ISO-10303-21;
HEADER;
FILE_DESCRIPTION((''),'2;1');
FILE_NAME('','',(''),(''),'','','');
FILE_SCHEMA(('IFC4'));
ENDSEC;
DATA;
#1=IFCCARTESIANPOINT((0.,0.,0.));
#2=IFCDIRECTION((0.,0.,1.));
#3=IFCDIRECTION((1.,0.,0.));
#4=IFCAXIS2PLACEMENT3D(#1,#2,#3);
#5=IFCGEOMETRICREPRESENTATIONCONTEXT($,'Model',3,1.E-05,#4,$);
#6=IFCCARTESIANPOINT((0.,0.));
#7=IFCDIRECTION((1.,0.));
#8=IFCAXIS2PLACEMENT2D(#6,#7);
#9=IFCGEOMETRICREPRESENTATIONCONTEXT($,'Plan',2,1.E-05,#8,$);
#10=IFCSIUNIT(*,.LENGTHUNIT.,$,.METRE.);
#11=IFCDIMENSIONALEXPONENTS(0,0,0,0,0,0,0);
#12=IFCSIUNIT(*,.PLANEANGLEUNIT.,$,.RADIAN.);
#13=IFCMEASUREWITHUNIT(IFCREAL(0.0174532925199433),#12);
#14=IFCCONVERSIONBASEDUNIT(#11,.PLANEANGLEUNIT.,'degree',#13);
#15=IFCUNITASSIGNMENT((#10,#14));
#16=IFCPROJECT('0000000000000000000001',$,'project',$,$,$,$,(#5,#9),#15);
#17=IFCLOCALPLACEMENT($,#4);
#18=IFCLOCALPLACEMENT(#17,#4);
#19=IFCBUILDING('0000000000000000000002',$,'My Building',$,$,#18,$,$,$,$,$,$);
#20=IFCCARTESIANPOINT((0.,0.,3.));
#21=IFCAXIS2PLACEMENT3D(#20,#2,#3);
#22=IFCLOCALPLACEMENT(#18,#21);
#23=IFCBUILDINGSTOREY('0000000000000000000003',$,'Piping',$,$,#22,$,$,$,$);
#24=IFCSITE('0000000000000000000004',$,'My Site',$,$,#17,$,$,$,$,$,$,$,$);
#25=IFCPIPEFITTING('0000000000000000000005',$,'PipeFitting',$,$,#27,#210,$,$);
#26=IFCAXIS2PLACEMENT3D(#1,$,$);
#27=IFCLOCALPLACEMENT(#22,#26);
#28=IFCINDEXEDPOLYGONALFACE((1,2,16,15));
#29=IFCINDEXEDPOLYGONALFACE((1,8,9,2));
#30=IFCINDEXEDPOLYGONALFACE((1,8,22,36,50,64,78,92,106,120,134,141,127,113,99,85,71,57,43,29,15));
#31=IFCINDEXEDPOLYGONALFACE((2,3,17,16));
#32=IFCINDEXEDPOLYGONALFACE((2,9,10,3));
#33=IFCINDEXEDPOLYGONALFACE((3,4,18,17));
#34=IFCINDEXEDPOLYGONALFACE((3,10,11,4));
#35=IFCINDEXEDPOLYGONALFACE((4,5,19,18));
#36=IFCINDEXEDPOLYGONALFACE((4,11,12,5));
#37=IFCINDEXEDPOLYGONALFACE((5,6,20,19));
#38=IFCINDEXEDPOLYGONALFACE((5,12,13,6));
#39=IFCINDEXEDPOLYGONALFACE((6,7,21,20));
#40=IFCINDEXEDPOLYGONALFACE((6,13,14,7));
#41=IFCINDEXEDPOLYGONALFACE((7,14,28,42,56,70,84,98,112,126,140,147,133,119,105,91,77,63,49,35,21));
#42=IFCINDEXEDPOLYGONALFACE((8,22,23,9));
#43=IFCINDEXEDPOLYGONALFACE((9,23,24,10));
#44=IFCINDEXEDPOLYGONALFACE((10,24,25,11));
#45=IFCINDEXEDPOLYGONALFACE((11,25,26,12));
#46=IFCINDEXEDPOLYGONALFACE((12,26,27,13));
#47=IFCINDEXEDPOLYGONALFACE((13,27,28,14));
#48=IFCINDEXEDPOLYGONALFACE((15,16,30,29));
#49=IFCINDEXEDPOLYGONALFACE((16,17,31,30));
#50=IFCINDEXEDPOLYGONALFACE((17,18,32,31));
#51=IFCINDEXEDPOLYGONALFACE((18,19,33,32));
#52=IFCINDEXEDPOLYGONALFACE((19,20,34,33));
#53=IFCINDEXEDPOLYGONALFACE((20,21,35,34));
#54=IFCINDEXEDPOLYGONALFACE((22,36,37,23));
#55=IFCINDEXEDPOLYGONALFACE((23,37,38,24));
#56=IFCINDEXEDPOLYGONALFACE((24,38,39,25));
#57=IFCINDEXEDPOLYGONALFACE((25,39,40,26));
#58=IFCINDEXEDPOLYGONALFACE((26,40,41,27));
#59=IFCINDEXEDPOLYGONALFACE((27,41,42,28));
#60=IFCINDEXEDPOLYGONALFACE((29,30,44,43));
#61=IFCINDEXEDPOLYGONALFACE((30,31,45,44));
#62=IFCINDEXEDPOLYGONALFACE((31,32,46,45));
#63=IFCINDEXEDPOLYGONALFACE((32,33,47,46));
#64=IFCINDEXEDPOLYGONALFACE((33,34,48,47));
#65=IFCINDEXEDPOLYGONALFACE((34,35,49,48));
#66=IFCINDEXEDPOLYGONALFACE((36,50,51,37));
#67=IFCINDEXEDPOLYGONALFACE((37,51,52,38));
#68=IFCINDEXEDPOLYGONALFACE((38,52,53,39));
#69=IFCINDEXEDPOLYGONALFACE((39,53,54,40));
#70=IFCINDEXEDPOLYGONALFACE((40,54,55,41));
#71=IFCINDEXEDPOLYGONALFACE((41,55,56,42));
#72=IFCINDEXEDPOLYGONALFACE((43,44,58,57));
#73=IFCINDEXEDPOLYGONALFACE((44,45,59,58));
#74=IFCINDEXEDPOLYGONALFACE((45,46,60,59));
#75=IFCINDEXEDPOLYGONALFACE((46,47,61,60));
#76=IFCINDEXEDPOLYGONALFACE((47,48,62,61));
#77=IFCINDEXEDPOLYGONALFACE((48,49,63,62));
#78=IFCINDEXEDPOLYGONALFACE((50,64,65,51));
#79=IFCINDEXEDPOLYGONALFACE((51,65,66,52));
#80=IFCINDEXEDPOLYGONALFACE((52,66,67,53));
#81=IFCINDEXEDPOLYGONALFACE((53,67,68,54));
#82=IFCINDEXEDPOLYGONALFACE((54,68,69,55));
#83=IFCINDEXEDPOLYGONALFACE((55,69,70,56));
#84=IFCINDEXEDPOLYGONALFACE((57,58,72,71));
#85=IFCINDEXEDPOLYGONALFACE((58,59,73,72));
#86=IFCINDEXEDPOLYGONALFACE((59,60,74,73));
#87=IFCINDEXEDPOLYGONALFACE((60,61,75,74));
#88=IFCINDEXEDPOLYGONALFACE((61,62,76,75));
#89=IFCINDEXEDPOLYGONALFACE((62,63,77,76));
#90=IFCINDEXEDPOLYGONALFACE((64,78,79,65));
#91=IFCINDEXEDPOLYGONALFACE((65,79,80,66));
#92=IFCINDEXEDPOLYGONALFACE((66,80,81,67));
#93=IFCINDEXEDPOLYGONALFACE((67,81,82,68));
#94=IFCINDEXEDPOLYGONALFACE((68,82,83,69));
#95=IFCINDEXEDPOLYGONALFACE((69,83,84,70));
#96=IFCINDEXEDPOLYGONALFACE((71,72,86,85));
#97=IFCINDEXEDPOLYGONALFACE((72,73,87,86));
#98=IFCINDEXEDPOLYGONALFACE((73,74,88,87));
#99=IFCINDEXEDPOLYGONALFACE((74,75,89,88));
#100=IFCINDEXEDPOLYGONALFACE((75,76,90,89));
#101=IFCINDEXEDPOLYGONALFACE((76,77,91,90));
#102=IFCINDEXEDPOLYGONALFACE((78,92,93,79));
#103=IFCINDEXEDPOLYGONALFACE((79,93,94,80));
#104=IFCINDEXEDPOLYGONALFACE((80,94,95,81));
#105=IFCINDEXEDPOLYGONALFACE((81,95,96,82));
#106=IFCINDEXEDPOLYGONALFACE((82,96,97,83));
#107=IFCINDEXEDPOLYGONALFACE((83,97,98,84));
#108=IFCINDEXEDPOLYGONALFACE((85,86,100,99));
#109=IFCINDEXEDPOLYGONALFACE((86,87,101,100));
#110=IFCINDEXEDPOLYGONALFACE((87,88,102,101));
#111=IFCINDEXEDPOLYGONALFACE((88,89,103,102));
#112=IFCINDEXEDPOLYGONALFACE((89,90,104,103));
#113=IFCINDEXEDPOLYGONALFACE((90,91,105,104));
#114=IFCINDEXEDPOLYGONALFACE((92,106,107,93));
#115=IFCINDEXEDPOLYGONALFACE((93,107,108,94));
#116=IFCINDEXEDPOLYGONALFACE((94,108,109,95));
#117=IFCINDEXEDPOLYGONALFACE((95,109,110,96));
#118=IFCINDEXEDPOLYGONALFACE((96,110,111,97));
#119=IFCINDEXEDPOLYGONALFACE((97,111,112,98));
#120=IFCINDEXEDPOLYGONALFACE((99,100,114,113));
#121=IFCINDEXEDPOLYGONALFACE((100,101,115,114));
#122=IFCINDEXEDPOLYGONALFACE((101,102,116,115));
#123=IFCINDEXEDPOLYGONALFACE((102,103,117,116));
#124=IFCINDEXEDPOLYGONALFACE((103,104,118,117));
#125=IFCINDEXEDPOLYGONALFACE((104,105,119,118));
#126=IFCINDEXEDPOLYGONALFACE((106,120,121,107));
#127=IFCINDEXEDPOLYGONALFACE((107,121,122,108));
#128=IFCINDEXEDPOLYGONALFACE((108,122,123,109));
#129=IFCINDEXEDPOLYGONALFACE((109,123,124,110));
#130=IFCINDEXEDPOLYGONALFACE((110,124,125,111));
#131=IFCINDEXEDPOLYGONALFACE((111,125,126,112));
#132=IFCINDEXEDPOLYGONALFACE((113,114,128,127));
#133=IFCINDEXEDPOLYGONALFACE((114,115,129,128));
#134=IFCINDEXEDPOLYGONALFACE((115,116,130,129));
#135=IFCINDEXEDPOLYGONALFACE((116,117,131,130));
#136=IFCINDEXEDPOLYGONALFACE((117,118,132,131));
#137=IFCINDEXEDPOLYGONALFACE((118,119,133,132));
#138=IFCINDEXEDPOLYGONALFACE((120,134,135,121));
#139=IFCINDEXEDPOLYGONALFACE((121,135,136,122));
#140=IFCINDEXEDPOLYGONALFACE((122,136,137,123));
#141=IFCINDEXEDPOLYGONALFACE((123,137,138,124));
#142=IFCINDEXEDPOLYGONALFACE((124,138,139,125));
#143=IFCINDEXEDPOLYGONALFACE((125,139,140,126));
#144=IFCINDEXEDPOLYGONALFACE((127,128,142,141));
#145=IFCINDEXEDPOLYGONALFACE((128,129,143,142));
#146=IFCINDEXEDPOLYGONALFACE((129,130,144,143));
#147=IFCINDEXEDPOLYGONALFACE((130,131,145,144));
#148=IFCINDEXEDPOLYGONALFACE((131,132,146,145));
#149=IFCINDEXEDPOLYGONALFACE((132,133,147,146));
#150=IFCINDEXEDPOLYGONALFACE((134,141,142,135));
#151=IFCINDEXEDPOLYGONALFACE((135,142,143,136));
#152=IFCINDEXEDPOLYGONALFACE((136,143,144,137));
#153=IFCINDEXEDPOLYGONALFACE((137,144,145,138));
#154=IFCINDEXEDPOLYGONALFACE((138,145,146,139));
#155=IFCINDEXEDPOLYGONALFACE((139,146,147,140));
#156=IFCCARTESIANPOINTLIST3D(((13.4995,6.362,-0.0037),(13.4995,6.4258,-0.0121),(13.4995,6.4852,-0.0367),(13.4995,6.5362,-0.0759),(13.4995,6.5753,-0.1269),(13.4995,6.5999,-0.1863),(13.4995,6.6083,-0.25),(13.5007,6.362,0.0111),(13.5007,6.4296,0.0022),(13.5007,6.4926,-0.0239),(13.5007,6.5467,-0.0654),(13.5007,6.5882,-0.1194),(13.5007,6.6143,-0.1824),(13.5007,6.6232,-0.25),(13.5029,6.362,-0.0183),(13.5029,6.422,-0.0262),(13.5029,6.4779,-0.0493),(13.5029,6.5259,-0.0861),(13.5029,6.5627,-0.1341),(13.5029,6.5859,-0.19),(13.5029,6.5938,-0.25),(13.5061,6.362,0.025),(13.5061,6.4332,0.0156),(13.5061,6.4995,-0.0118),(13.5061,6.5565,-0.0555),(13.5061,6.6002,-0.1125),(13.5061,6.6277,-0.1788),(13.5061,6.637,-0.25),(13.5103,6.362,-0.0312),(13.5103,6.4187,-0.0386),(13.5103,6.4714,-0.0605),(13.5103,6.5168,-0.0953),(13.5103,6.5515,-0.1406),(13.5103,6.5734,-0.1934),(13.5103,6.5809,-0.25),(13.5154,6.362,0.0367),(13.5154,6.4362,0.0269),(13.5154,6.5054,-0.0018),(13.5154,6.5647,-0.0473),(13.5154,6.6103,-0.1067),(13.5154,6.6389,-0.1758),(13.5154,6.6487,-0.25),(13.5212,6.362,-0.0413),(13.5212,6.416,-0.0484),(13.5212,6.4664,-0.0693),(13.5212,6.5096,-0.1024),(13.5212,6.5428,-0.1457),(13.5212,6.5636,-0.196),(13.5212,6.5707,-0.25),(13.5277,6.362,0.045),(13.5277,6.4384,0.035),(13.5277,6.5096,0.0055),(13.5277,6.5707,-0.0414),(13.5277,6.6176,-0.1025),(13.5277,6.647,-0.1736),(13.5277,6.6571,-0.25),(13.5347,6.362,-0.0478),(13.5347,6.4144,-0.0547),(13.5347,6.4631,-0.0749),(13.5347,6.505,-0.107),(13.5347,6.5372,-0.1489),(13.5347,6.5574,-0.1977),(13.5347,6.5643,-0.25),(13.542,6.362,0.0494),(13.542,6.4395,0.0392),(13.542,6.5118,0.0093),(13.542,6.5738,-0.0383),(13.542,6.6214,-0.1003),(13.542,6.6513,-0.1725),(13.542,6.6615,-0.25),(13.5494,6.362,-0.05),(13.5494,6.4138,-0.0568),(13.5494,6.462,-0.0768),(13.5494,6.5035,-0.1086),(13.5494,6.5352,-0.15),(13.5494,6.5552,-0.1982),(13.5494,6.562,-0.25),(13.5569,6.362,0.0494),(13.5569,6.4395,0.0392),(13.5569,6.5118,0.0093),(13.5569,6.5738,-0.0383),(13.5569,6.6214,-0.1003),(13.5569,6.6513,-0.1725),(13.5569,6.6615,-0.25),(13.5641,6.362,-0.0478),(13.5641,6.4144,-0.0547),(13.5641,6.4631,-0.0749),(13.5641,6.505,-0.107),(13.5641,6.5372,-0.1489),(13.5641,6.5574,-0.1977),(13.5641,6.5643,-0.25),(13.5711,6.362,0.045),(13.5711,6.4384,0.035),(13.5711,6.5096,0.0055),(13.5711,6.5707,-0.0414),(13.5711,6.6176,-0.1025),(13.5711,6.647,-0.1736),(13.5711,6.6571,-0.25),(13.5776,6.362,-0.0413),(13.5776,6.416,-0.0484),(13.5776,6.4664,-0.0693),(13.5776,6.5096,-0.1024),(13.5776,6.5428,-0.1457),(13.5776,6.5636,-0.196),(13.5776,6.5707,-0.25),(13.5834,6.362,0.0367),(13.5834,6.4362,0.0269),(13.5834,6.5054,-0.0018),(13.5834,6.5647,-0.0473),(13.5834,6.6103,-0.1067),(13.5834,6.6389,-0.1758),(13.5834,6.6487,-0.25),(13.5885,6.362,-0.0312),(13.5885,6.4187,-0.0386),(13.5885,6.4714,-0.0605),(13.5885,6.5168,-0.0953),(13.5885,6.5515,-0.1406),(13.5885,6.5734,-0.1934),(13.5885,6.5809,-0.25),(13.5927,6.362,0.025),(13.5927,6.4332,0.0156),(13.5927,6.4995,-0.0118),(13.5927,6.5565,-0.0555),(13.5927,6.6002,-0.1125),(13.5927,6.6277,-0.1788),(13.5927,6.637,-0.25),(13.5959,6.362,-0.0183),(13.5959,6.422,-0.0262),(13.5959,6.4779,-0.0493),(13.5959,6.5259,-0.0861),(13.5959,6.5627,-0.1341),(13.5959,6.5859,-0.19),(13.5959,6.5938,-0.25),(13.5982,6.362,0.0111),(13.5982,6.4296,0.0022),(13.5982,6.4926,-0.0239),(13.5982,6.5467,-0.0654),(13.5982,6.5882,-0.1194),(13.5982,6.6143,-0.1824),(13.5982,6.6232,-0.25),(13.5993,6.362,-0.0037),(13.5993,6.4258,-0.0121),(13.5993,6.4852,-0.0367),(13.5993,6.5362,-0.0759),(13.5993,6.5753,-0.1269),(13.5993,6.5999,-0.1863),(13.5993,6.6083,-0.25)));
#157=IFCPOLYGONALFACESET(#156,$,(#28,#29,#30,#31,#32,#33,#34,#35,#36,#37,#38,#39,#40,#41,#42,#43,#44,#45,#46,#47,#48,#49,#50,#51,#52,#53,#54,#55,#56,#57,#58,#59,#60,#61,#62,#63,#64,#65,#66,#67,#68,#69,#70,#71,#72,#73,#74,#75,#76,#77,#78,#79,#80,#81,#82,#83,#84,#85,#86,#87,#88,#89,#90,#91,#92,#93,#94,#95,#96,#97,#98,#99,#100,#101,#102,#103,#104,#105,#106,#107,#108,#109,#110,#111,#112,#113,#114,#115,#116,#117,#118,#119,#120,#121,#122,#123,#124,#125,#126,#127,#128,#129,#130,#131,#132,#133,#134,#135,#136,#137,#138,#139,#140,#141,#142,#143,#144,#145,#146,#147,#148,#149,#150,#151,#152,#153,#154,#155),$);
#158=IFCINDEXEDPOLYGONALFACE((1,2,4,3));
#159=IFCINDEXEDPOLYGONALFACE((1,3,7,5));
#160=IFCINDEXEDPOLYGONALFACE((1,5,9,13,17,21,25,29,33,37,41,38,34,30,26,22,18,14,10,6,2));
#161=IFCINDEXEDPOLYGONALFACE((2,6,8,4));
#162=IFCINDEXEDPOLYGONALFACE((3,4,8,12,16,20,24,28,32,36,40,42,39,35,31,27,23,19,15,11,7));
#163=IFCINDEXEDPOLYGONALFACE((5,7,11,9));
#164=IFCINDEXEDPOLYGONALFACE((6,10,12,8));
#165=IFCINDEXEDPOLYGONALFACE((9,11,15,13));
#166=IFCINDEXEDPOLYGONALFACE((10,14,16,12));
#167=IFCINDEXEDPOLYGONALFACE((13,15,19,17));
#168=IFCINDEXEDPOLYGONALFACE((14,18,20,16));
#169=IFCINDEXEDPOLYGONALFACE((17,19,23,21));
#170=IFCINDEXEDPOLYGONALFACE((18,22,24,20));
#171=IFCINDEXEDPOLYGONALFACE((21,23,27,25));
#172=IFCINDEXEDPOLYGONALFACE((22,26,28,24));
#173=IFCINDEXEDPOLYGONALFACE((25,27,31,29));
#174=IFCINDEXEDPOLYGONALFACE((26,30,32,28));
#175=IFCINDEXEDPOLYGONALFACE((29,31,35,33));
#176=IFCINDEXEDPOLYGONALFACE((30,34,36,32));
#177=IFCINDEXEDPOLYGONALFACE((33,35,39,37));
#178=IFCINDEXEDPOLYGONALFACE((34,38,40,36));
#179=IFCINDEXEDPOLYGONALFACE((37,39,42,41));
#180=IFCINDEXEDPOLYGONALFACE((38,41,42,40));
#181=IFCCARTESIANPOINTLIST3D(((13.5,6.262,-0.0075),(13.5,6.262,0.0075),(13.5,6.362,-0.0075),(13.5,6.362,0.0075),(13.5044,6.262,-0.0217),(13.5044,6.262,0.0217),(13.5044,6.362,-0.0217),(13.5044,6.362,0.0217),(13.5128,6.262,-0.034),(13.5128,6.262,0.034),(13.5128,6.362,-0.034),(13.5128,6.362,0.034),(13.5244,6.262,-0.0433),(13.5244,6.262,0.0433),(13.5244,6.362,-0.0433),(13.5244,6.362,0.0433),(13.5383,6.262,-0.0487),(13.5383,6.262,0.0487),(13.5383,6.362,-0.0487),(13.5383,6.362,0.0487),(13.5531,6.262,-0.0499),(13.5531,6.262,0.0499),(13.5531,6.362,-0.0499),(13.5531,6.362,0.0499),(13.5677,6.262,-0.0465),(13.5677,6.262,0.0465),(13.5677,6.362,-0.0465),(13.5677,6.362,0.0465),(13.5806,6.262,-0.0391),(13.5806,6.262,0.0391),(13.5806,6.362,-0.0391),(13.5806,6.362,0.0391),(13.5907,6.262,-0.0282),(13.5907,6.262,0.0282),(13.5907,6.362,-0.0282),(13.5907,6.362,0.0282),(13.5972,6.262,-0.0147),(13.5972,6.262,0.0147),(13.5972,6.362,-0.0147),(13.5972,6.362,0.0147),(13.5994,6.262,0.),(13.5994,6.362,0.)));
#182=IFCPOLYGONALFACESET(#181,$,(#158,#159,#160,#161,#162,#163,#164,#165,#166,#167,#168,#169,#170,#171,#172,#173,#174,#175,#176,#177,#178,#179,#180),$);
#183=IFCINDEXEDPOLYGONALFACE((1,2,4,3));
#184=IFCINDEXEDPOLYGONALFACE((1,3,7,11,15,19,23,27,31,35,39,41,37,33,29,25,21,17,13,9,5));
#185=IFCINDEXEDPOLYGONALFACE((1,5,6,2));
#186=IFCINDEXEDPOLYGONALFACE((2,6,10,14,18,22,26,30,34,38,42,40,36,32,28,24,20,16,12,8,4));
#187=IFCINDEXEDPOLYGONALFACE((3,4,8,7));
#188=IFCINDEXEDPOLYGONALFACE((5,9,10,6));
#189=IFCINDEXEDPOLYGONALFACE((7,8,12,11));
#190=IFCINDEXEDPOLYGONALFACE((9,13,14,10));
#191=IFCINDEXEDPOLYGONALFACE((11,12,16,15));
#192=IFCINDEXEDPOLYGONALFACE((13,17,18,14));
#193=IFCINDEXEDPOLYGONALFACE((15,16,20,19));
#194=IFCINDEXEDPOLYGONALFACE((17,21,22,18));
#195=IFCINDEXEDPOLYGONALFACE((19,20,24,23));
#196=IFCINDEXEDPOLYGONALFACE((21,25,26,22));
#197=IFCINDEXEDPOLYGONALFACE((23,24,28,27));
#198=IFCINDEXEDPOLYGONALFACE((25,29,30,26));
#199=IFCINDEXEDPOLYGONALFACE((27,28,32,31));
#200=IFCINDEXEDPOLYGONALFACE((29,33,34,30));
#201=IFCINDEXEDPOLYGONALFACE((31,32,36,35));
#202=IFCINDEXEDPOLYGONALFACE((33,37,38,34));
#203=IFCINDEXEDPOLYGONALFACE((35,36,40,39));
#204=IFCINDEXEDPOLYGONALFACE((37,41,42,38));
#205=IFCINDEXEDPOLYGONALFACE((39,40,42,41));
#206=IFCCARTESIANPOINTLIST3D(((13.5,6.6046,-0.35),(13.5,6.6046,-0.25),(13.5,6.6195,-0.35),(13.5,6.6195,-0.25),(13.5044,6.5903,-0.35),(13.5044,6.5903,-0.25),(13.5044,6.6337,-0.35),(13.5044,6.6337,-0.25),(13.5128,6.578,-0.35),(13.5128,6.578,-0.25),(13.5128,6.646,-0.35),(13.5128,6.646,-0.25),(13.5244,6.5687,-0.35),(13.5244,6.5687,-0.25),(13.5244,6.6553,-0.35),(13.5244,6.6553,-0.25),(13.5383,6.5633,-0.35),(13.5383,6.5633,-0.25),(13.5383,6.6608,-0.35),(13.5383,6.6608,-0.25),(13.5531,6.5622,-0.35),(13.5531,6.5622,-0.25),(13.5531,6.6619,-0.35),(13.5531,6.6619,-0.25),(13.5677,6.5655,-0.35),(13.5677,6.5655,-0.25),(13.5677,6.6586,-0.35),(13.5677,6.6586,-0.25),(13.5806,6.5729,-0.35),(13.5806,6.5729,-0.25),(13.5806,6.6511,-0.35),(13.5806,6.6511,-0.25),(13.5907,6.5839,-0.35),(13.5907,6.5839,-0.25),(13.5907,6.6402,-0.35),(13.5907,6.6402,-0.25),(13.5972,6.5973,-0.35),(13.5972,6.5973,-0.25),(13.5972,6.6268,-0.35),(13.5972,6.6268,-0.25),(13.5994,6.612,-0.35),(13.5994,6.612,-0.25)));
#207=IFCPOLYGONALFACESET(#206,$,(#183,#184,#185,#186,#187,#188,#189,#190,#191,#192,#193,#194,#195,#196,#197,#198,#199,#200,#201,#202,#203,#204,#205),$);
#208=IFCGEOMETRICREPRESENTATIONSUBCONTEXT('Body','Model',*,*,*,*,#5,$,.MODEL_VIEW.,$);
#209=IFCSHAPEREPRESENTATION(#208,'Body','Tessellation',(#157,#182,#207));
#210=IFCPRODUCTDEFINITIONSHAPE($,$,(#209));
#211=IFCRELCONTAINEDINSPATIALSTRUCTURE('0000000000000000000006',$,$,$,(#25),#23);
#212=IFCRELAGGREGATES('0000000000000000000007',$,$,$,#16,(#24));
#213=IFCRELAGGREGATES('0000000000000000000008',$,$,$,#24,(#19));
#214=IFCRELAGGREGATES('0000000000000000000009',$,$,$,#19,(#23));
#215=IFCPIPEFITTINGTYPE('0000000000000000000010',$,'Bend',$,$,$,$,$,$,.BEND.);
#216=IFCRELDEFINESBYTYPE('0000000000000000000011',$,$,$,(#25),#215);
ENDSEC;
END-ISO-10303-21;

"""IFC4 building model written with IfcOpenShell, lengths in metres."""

from ifc_helpers import new_model, entity, si_unit, converted_unit, frame, origin_with_axes, origin_2d_with_axis, place, context, subcontext, project, spatial, circle, extrude, source, transform, mapped, type_object, type_shapes, element, save


model = new_model("IFC4")

# Units and contexts
model_context = context("Model", 3, precision=1e-05, world=origin_with_axes())
plan_context = context("Plan", 2, precision=1e-05, world=origin_2d_with_axis())
body_context = subcontext(model_context, "Body", "Model", "MODEL_VIEW")
ifc_project = project(units=[si_unit("LENGTHUNIT", "METRE"), converted_unit("PLANEANGLEUNIT", "degree", entity("IfcReal", 0.0174532925199433), si_unit("PLANEANGLEUNIT", "RADIAN"), dimensions=[0, 0, 0, 0, 0, 0, 0])], contexts=[model_context, plan_context])

# Site, building, storey
site_placement = place(None, origin_with_axes())
site = spatial("IfcSite", under=ifc_project, at=site_placement, Name="My Site")
building_placement = place(site_placement, origin_with_axes())
building = spatial("IfcBuilding", under=site, at=building_placement, Name="My Building")
storey_placement = place(building_placement, frame((0.0, 0.0, 3.0), z_axis=(0.0, 0.0, 1.0), x_axis=(1.0, 0.0, 0.0)))
storey = spatial("IfcBuildingStorey", under=building, at=storey_placement, Name="Piping")

# Pipe fitting
pipe_fitting_type = type_object("IfcPipeFittingType", Name="Bend", PredefinedType="BEND")
shared_shape = source(origin_with_axes(), body_context, "Body", "SolidModel", [
    entity("IfcSweptDiskSolid", entity("IfcIndexedPolyCurve", entity("IfcCartesianPointList3D", [[0.0, 0.0, -0.1], [0.0, -0.0732, -0.2768], [0.0, -0.25, -0.35]]), [entity("IfcArcIndex", [1, 2, 3])]), 0.05),
    extrude(circle(Radius=0.05), origin_with_axes(), (0.0, 0.0, -1.0), 0.1),
    extrude(circle(Radius=0.05), frame((0.0, -0.25, -0.35), z_axis=(0.0, -1.0, 0.0), x_axis=(1.0, 0.0, 0.0)), (0.0, 0.0, 1.0), 0.1),
])
type_shapes(pipe_fitting_type, [shared_shape])
for number, where, z_axis, x_axis, name in (
    (1, (13.5494, 6.262, 0.0), (0.0, -1.0, 0.0), (1.0, 0.0, 0.0), "PipeFitting"),
):
    element("IfcPipeFitting", number, at=place(storey_placement, frame(where, z_axis=z_axis, x_axis=x_axis)), inside=storey, type_object=pipe_fitting_type, Name=name, context=body_context, shape_type="MappedRepresentation", body=[
        mapped(shared_shape, transform((0.0, 0.0, 0.0), x_axis=(1.0, 0.0, 0.0), y_axis=(0.0, 1.0, 0.0), z_axis=(0.0, 0.0, 1.0), scale=1.0)),
    ])

save(model, "model.ifc")
